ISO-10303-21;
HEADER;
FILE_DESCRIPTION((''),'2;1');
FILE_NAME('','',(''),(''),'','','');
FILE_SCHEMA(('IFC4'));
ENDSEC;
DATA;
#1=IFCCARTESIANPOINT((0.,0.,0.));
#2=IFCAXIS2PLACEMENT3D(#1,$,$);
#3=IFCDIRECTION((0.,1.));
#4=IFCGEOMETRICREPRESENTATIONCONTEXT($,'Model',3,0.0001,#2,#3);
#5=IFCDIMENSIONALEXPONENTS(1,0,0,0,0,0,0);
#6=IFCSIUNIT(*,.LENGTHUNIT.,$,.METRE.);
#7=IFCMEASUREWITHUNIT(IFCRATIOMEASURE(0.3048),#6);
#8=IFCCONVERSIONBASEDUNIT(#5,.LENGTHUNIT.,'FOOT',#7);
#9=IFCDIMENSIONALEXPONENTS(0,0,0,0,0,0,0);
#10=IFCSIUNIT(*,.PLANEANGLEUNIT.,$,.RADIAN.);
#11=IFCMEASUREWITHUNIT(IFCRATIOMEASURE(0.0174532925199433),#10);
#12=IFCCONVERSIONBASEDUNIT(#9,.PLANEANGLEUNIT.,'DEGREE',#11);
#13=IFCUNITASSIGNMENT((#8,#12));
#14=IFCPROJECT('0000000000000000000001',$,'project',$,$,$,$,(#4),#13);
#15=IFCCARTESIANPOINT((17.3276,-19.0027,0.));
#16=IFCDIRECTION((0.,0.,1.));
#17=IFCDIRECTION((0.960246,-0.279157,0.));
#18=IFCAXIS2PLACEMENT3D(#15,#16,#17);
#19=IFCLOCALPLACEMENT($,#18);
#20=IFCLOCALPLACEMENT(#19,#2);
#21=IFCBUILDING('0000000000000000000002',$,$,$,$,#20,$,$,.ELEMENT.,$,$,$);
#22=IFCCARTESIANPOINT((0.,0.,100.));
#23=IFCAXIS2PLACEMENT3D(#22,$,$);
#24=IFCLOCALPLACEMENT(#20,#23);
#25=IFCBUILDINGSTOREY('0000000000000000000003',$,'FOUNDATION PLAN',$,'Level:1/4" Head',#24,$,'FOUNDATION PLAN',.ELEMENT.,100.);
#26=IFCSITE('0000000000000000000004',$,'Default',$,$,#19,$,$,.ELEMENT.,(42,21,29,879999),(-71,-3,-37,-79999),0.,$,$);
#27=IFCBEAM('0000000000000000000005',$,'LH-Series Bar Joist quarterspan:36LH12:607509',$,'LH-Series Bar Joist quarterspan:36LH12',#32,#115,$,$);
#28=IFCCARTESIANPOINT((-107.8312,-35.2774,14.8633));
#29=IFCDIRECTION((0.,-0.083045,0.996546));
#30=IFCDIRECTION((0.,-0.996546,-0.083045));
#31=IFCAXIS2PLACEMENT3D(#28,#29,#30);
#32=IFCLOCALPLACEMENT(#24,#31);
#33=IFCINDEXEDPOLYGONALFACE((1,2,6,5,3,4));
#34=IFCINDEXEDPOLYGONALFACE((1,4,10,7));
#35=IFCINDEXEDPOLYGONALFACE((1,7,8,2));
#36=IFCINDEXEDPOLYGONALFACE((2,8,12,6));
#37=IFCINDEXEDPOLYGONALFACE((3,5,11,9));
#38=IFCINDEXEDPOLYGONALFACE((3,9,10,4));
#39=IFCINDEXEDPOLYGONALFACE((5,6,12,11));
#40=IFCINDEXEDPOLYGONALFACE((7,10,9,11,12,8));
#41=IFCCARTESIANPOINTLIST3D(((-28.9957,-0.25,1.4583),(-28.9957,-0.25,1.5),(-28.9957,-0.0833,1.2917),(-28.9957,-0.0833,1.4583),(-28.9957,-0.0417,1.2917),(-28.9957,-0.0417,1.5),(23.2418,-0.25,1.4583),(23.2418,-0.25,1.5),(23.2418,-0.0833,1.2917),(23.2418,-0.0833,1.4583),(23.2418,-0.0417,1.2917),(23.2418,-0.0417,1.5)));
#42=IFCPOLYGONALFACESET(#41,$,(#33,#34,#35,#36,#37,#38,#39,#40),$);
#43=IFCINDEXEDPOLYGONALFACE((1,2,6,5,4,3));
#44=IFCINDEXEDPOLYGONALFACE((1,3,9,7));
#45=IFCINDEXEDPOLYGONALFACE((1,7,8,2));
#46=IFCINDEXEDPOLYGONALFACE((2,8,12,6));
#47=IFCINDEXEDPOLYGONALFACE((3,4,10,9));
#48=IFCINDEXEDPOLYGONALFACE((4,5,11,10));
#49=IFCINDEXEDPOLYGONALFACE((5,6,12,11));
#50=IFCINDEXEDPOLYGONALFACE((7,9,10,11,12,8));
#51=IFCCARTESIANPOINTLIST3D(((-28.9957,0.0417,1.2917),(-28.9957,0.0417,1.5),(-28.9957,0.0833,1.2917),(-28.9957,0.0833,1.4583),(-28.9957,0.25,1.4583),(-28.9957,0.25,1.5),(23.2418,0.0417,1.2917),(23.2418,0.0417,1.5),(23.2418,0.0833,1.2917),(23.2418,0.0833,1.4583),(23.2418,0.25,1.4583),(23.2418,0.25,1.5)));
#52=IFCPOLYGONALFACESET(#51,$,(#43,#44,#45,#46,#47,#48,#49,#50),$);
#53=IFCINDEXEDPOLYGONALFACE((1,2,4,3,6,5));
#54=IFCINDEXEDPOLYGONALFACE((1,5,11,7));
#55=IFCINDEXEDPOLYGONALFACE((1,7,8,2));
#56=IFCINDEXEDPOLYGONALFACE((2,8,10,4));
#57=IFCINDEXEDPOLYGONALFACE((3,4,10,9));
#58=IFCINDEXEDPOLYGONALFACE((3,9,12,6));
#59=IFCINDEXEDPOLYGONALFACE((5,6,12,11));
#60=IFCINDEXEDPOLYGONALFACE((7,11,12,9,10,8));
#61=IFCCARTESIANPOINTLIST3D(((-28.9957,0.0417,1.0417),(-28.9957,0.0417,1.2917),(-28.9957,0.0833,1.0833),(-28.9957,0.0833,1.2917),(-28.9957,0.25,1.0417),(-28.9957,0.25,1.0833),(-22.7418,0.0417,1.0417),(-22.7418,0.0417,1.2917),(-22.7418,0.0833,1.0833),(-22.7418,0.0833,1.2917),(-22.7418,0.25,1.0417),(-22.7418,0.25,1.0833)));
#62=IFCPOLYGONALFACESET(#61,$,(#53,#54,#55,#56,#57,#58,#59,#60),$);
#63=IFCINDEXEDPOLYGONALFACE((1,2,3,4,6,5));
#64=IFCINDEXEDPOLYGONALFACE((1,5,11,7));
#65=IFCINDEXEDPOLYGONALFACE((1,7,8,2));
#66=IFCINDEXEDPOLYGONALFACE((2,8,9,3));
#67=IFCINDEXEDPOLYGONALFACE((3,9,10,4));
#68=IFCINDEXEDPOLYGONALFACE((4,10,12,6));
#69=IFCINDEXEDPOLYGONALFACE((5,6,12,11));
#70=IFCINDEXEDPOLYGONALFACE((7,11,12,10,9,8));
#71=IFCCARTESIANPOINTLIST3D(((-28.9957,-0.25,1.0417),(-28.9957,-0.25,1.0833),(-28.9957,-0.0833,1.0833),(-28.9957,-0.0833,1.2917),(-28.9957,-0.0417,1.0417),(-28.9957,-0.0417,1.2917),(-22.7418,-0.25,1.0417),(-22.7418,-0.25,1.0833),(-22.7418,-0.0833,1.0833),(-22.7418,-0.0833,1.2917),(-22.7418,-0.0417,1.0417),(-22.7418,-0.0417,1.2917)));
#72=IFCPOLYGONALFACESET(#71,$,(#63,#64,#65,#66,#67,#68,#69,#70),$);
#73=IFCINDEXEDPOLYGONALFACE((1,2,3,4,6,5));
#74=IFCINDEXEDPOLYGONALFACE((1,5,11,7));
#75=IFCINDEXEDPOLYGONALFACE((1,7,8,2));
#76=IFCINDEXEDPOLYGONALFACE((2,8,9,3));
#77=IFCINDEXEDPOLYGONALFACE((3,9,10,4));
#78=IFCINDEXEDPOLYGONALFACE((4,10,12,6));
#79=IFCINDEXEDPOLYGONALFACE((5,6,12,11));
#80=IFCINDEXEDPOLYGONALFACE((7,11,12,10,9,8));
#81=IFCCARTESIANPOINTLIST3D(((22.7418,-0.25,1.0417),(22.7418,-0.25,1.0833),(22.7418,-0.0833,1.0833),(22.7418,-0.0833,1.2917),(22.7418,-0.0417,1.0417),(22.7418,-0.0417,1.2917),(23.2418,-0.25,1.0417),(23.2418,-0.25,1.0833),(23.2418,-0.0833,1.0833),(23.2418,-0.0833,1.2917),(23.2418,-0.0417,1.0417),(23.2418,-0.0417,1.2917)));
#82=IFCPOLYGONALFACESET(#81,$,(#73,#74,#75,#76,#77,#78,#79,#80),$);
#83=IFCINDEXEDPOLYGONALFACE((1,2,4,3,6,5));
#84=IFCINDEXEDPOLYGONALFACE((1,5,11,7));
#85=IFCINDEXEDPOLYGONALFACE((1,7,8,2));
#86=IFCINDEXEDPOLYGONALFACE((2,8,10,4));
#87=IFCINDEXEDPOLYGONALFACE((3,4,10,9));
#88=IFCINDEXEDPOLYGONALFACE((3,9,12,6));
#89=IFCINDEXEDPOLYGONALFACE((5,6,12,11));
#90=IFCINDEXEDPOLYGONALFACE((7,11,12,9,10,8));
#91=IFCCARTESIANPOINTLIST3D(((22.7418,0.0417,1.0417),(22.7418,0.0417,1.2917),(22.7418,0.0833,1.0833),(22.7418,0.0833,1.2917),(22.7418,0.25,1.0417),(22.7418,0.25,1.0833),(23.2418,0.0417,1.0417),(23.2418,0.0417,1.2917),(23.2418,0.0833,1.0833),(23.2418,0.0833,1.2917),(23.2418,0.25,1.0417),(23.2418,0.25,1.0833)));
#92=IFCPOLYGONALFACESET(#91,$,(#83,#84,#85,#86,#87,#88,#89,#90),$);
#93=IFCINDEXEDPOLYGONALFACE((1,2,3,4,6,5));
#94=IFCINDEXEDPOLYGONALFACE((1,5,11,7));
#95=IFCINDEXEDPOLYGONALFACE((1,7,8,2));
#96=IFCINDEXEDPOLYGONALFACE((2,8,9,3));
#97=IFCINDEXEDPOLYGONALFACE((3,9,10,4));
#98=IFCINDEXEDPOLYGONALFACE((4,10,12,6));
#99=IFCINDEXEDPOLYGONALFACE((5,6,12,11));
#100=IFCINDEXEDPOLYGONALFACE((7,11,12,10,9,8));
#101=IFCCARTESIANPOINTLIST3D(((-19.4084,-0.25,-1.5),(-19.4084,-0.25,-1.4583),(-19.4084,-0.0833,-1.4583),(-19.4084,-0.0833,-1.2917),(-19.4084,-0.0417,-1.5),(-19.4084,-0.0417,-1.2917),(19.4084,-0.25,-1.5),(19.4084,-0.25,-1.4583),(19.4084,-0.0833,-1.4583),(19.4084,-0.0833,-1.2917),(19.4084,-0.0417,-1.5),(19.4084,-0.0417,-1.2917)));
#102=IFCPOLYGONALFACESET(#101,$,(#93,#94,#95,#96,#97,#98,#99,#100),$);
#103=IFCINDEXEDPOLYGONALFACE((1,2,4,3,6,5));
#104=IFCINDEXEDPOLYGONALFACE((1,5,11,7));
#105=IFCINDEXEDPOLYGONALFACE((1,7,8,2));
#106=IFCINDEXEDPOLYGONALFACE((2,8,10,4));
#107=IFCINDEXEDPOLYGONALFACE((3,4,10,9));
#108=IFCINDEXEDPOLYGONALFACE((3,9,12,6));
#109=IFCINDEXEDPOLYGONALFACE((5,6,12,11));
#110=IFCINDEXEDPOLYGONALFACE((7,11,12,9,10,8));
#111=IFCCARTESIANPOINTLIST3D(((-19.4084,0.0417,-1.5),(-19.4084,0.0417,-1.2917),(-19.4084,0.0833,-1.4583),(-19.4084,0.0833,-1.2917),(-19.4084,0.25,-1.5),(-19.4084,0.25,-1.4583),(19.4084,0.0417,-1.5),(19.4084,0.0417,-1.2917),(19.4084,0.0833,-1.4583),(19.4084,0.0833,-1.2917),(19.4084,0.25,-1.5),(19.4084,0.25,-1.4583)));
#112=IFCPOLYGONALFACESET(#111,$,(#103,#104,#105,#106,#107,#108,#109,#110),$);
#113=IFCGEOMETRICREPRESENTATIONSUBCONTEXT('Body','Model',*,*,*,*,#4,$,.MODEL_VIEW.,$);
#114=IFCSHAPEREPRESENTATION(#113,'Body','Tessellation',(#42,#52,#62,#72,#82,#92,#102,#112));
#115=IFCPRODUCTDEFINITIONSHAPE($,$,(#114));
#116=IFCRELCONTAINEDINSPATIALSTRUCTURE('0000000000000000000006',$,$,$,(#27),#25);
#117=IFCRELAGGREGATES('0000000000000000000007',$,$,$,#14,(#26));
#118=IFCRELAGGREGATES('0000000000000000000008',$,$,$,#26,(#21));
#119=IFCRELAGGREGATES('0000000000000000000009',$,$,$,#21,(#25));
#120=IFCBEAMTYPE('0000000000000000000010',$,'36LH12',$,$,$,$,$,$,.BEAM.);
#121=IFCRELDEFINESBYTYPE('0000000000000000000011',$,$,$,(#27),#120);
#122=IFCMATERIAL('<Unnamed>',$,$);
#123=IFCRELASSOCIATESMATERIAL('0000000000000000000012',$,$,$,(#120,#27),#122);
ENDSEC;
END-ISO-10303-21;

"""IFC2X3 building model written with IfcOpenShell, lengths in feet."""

from ifc_helpers import new_model, entity, si_unit, converted_unit, direction, frame, origin, place, context, subcontext, project, spatial, polyline, outline, extrude, source, transform, mapped, material, type_object, type_shapes, element, save


model = new_model("IFC2X3")

# Units and contexts
model_context = context("Model", 3, precision=0.0001, world=origin(), true_north=direction((0.0, 1.0)))
body_context = subcontext(model_context, "Body", "Model", "MODEL_VIEW")
ifc_project = project(units=[converted_unit("LENGTHUNIT", "FOOT", entity("IfcRatioMeasure", 0.3048), si_unit("LENGTHUNIT", "METRE"), dimensions=[1, 0, 0, 0, 0, 0, 0]), converted_unit("PLANEANGLEUNIT", "DEGREE", entity("IfcRatioMeasure", 0.0174532925199433), si_unit("PLANEANGLEUNIT", "RADIAN"), dimensions=[0, 0, 0, 0, 0, 0, 0])], contexts=[model_context])

# Site, building, storey
site_placement = place(None, frame((17.3276, -19.0027, 0.0), z_axis=(0.0, 0.0, 1.0), x_axis=(0.960246, -0.279157, 0.0)))
site = spatial("IfcSite", under=ifc_project, at=site_placement, Name="Default", CompositionType="ELEMENT", RefLatitude=(42, 21, 29, 879999), RefLongitude=(-71, -3, -37, -79999), RefElevation=0.0)
building_placement = place(site_placement, origin())
building = spatial("IfcBuilding", under=site, at=building_placement, CompositionType="ELEMENT")
storey_placement = place(building_placement, frame((0.0, 0.0, 100.0)))
storey = spatial("IfcBuildingStorey", under=building, at=storey_placement, Name="FOUNDATION PLAN", ObjectType="Level:1/4\" Head", LongName="FOUNDATION PLAN", CompositionType="ELEMENT", Elevation=100.0)

# Shared definitions
ifc_material_1 = material(Name="<Unnamed>")

# Beam
beam_type_1 = type_object("IfcBeamType", Name="36LH12", PredefinedType="BEAM", material=ifc_material_1)
shared_shape_1 = source(origin(), body_context, "Body", "SweptSolid", [
    extrude(outline(polyline([(-0.0833, -0.125), (-0.0417, -0.125), (-0.0417, 0.0417), (0.125, 0.0417), (0.125, 0.0833), (-0.0833, 0.0833), (-0.0833, -0.125)])), frame((-28.9957, -0.125, 1.4167), z_axis=(1.0, 0.0, 0.0), x_axis=(0.0, 0.0, -1.0)), (0.0, 0.0, 1.0), 52.2374),
    extrude(outline(polyline([(-0.0833, -0.0833), (0.125, -0.0833), (0.125, -0.0417), (-0.0417, -0.0417), (-0.0417, 0.125), (-0.0833, 0.125), (-0.0833, -0.0833)])), frame((-28.9957, 0.125, 1.4167), z_axis=(1.0, 0.0, 0.0), x_axis=(0.0, 0.0, -1.0)), (0.0, 0.0, 1.0), 52.2374),
    extrude(outline(polyline([(-0.1528, -0.0833), (0.0972, -0.0833), (0.0972, 0.125), (0.0556, 0.125), (0.0556, -0.0417), (-0.1528, -0.0417), (-0.1528, -0.0833)])), frame((-28.9957, 0.125, 1.1389), z_axis=(1.0, 0.0, 0.0), x_axis=(0.0, 0.0, -1.0)), (0.0, 0.0, 1.0), 6.2539),
    extrude(outline(polyline([(0.0556, -0.125), (0.0972, -0.125), (0.0972, 0.0833), (-0.1528, 0.0833), (-0.1528, 0.0417), (0.0556, 0.0417), (0.0556, -0.125)])), frame((-28.9957, -0.125, 1.1389), z_axis=(1.0, 0.0, 0.0), x_axis=(0.0, 0.0, -1.0)), (0.0, 0.0, 1.0), 6.2539),
    extrude(outline(polyline([(0.0556, -0.125), (0.0972, -0.125), (0.0972, 0.0833), (-0.1528, 0.0833), (-0.1528, 0.0417), (0.0556, 0.0417), (0.0556, -0.125)])), frame((22.7418, -0.125, 1.1389), z_axis=(1.0, 0.0, 0.0), x_axis=(0.0, 0.0, -1.0)), (0.0, 0.0, 1.0), 0.5),
    extrude(outline(polyline([(-0.1528, -0.0833), (0.0972, -0.0833), (0.0972, 0.125), (0.0556, 0.125), (0.0556, -0.0417), (-0.1528, -0.0417), (-0.1528, -0.0833)])), frame((22.7418, 0.125, 1.1389), z_axis=(1.0, 0.0, 0.0), x_axis=(0.0, 0.0, -1.0)), (0.0, 0.0, 1.0), 0.5),
    extrude(outline(polyline([(0.0417, -0.125), (0.0833, -0.125), (0.0833, 0.0833), (-0.125, 0.0833), (-0.125, 0.0417), (0.0417, 0.0417), (0.0417, -0.125)])), frame((-19.4084, -0.125, -1.4167), z_axis=(1.0, 0.0, 0.0), x_axis=(0.0, 0.0, -1.0)), (0.0, 0.0, 1.0), 38.8169),
    extrude(outline(polyline([(-0.125, -0.0833), (0.0833, -0.0833), (0.0833, 0.125), (0.0417, 0.125), (0.0417, -0.0417), (-0.125, -0.0417), (-0.125, -0.0833)])), frame((-19.4084, 0.125, -1.4167), z_axis=(1.0, 0.0, 0.0), x_axis=(0.0, 0.0, -1.0)), (0.0, 0.0, 1.0), 38.8169),
])
type_shapes(beam_type_1, [shared_shape_1])
beam_1_placement = place(storey_placement, frame((-107.8312, -35.2774, 14.8633), z_axis=(0.0, -0.083045, 0.996546), x_axis=(0.0, -0.996546, -0.083045)))
element("IfcBeam", 1, at=beam_1_placement, inside=storey, type_object=beam_type_1, material=ifc_material_1, Name="LH-Series Bar Joist quarterspan:36LH12:607509", ObjectType="LH-Series Bar Joist quarterspan:36LH12", context=body_context, shape_type="MappedRepresentation", body=[
    mapped(shared_shape_1, transform((0.0, 0.0, 0.0), scale=1.0)),
])

save(model, "model.ifc")
